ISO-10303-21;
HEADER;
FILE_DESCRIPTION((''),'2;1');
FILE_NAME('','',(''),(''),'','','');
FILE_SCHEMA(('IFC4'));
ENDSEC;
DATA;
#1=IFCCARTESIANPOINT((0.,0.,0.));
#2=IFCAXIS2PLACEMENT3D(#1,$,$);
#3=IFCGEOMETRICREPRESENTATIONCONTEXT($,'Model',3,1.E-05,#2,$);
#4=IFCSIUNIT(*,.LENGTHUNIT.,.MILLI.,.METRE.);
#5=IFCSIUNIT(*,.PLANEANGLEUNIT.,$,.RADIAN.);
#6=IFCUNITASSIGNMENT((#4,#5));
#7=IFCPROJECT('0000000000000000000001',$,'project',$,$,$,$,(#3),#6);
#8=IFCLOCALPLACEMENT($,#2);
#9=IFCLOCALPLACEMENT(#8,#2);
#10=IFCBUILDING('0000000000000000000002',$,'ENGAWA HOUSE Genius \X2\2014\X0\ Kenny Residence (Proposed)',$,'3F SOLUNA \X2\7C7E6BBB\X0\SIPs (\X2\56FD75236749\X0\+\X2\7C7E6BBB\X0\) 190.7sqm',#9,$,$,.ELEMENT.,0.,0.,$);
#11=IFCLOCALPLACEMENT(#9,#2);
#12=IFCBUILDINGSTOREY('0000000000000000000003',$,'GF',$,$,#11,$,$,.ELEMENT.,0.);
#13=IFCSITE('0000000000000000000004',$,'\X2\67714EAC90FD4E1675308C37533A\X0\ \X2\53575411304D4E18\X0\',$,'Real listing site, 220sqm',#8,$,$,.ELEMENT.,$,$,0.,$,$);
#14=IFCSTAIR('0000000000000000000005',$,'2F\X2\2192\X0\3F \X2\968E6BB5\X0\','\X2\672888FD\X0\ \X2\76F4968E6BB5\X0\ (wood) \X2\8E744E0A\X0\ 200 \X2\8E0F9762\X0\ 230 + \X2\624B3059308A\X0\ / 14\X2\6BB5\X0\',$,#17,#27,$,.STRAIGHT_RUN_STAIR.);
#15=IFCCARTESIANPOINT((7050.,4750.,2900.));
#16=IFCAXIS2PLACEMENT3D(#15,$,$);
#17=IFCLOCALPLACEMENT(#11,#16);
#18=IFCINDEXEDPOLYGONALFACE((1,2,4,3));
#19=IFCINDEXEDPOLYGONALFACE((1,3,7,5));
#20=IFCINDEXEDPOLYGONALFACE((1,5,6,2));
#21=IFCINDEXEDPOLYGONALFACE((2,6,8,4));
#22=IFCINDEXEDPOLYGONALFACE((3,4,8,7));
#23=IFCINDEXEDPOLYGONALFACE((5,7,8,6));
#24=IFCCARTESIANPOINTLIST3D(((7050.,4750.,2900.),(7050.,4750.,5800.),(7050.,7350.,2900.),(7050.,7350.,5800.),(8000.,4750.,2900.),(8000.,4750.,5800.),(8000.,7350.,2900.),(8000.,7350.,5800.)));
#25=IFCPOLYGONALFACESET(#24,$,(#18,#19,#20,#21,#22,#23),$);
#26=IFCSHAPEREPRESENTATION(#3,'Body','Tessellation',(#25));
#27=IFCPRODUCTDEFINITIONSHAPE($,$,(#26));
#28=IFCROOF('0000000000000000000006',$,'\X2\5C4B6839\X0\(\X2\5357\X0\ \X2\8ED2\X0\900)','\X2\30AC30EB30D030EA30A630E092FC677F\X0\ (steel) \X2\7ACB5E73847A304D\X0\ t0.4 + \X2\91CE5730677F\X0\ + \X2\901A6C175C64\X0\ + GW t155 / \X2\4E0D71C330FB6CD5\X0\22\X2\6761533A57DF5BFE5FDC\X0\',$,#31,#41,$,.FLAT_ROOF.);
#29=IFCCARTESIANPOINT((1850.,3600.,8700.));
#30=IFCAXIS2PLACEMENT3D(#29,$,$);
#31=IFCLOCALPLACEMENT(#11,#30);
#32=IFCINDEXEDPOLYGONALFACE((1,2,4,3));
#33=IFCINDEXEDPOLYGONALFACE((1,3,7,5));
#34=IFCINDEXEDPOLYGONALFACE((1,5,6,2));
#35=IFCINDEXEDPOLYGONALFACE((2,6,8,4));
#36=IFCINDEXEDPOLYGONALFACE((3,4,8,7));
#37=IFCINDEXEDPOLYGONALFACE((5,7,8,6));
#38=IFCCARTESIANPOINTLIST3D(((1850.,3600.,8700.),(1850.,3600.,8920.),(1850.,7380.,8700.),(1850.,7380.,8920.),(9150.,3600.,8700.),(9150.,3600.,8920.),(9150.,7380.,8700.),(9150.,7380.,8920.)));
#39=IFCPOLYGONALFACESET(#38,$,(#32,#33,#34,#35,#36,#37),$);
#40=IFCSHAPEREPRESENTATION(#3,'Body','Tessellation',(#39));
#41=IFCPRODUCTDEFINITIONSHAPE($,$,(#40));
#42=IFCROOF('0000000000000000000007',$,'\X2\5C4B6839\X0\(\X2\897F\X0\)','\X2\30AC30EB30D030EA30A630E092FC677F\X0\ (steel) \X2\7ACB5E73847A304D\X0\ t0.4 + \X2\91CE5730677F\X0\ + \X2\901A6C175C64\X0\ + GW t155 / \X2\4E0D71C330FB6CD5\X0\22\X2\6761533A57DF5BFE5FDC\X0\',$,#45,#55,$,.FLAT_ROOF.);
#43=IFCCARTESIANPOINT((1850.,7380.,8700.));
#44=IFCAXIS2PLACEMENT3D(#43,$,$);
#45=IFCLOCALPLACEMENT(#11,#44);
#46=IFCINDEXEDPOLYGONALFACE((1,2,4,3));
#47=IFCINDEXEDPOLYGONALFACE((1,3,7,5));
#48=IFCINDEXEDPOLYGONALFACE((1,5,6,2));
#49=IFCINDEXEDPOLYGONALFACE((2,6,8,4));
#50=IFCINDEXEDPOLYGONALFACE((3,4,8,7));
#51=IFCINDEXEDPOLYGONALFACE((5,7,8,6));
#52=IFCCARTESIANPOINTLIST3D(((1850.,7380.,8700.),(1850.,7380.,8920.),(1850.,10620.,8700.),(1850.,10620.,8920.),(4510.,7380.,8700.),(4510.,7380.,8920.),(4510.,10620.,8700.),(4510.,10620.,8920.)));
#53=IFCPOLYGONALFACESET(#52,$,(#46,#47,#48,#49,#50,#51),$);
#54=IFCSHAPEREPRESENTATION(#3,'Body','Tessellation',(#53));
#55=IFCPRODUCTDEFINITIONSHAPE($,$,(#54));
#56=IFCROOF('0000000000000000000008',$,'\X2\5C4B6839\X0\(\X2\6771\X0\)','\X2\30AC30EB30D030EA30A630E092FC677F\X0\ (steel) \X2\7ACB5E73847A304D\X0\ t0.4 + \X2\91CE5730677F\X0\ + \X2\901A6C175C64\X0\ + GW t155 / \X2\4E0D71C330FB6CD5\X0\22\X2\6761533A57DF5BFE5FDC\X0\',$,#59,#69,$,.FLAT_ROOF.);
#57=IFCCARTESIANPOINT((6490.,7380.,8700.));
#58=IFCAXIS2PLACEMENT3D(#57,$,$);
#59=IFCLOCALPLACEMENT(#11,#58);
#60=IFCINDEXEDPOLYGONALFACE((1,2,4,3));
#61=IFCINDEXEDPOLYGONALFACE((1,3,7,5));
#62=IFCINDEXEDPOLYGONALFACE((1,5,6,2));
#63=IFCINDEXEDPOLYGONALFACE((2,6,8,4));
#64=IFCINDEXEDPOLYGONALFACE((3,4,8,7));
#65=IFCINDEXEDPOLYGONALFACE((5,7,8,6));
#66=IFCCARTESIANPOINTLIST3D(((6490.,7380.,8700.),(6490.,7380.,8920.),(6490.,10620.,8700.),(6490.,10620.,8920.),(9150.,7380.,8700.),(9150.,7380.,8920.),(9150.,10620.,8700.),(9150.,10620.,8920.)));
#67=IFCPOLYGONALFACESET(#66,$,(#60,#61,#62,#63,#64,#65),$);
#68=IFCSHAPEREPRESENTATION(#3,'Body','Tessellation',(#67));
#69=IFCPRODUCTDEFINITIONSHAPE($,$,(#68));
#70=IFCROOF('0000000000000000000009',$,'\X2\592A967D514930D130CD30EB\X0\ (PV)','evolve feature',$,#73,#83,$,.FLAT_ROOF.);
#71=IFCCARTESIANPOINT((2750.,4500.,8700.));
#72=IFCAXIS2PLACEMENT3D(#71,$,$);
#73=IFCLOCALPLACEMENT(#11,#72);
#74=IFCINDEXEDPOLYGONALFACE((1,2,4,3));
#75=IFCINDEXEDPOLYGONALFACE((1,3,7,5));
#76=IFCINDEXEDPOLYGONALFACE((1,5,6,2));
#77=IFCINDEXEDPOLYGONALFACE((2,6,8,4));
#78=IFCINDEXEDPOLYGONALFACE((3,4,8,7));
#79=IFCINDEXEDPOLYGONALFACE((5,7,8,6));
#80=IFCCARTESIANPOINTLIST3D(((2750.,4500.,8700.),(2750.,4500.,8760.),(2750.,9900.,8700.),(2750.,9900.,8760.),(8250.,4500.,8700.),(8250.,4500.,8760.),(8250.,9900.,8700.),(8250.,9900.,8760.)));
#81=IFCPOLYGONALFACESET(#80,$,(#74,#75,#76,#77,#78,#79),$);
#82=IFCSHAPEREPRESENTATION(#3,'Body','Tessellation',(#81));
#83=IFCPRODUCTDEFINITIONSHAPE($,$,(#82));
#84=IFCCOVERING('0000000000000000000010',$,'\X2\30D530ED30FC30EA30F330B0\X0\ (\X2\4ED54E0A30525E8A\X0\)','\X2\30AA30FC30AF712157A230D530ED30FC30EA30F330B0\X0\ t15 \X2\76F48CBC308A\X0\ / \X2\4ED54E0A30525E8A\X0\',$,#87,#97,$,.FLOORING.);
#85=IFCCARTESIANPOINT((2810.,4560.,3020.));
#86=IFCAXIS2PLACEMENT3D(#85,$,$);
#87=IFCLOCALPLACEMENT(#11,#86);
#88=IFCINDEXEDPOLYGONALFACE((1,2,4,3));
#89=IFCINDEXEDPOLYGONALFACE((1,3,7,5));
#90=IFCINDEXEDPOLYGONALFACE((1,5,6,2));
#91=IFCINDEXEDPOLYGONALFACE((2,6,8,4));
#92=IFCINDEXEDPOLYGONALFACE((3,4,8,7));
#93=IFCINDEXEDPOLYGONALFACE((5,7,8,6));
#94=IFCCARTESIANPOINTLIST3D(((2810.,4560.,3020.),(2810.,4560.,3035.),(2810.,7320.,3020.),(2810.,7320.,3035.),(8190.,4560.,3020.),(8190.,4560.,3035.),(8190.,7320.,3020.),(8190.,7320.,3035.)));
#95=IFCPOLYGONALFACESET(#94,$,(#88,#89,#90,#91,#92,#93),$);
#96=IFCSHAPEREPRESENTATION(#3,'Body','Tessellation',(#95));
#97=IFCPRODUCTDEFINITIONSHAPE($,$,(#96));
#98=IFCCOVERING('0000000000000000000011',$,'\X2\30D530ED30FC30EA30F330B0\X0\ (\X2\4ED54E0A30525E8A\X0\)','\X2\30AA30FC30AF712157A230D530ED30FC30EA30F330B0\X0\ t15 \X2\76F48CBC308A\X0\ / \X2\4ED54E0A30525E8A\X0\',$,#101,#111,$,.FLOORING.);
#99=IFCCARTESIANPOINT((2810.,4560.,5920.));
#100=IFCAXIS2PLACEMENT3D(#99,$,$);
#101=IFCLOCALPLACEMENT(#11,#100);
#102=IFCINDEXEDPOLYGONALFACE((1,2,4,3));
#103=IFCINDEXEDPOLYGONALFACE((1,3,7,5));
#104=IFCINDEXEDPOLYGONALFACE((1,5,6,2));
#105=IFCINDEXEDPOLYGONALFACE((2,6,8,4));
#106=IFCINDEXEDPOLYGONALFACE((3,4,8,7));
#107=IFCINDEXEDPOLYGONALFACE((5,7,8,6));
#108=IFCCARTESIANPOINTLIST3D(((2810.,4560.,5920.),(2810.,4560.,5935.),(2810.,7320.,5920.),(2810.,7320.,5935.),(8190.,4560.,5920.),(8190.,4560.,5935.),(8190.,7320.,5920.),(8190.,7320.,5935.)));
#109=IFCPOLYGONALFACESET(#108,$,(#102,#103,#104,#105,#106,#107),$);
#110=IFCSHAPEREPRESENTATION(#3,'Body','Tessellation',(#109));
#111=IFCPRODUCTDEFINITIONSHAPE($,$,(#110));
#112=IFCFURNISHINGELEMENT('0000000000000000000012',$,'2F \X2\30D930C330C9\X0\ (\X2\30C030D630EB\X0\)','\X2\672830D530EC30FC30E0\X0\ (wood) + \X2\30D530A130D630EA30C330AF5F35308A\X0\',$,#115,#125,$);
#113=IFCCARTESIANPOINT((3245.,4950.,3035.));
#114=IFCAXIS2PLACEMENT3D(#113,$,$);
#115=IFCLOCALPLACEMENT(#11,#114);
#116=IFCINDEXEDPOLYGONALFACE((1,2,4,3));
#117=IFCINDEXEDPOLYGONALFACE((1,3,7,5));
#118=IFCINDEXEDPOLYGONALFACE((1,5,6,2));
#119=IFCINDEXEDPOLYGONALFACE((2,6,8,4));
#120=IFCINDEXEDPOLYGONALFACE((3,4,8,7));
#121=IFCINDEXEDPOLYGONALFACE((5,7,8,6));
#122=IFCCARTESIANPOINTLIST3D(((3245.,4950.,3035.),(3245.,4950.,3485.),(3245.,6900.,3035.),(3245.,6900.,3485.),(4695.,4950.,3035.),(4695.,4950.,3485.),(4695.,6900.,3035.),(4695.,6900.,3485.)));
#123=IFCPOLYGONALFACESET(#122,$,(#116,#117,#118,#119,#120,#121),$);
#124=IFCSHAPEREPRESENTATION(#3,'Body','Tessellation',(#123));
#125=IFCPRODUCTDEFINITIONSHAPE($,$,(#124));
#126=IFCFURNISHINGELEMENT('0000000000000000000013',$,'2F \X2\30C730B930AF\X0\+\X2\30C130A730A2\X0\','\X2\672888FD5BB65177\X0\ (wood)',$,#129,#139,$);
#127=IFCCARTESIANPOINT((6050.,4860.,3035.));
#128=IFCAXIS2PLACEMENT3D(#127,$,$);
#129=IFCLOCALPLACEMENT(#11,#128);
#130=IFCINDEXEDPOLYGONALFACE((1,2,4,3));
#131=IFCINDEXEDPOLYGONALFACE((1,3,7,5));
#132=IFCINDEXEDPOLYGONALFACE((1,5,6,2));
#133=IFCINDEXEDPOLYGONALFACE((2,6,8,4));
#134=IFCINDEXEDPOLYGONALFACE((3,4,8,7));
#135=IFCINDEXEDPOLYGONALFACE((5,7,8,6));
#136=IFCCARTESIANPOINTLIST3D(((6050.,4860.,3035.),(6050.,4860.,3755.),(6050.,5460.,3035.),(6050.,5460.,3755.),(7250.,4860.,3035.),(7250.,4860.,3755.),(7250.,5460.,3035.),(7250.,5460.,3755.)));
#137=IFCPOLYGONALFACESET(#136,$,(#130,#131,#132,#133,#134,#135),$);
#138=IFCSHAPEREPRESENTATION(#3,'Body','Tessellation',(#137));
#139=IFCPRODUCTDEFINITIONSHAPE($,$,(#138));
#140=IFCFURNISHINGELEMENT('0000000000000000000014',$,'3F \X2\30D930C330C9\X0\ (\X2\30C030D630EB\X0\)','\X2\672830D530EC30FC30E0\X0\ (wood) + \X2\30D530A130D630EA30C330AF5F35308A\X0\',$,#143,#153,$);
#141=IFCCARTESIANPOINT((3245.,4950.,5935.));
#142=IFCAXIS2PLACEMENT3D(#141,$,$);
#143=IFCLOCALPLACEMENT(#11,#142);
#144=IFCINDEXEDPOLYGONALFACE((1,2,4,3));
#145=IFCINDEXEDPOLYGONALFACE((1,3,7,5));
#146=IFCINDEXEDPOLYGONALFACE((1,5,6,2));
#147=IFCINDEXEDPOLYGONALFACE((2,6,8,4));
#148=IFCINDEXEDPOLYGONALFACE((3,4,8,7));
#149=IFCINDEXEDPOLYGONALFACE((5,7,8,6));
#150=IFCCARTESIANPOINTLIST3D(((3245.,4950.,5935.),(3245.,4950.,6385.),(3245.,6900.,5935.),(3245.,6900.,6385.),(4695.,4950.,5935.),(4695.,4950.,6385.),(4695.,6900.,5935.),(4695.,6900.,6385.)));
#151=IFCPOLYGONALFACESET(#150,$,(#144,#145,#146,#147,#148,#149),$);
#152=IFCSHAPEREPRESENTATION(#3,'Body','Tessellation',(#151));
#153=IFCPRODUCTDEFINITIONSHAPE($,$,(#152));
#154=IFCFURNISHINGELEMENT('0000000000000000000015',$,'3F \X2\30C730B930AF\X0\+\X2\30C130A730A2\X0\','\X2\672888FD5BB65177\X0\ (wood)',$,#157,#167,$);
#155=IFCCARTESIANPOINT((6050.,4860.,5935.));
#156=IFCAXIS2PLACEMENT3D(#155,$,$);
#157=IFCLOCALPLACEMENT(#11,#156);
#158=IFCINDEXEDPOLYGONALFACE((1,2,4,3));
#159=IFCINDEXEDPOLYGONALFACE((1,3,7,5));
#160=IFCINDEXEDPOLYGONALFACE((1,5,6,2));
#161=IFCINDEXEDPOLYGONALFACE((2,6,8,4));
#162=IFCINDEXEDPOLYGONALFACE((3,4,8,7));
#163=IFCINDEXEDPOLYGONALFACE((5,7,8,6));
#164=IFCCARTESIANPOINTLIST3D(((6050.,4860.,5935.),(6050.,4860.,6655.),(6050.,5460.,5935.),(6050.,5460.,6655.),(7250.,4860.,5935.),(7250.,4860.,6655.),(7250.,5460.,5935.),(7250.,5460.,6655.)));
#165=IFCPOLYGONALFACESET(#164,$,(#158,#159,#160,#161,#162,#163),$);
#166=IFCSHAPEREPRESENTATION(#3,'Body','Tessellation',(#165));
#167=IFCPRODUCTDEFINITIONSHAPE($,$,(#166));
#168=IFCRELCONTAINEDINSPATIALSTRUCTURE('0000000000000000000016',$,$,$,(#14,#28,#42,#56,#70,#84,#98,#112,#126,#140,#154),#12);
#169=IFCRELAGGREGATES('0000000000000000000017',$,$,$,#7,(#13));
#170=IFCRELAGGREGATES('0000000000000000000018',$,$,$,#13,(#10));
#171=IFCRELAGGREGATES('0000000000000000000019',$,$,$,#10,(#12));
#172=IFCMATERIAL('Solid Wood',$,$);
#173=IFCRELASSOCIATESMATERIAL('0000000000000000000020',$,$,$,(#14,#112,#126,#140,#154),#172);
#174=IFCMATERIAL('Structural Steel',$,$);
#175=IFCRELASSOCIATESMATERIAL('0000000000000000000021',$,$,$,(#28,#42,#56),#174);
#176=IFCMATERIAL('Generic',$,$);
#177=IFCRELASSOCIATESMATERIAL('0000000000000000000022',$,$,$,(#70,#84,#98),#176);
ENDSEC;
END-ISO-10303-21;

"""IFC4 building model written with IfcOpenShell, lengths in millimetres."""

from ifc_helpers import new_model, si_unit, frame, frame_2d, origin, place, context, project, spatial, rectangle, extrude, material, element, save


model = new_model("IFC4")

# Units and contexts
model_context = context("Model", 3, precision=1e-05, world=origin())
ifc_project = project(units=[si_unit("LENGTHUNIT", "METRE", prefix="MILLI"), si_unit("PLANEANGLEUNIT", "RADIAN")], contexts=[model_context])

# Site, building, storey
site_placement = place(None, origin())
site = spatial("IfcSite", under=ifc_project, at=site_placement, Name="東京都世田谷区 南向き丘", ObjectType="Real listing site, 220sqm", CompositionType="ELEMENT", RefElevation=0.0)
building_placement = place(site_placement, origin())
building = spatial("IfcBuilding", under=site, at=building_placement, Name="ENGAWA HOUSE Genius — Kenny Residence (Proposed)", ObjectType="3F SOLUNA 籾殻SIPs (国産杉+籾殻) 190.7sqm", CompositionType="ELEMENT", ElevationOfRefHeight=0.0, ElevationOfTerrain=0.0)
storey_placement = place(building_placement, origin())
storey = spatial("IfcBuildingStorey", under=building, at=storey_placement, Name="GF", CompositionType="ELEMENT", Elevation=0.0)

# Shared definitions
ifc_material_1 = material(Name="Solid Wood")

# Stair
stair_placement = place(storey_placement, frame((7050.0, 4750.0, 2900.0)))
element("IfcStair", 1, at=stair_placement, inside=storey, material=ifc_material_1, Name="2F→3F 階段", Description="木製 直階段 (wood) 蹴上 200 踏面 230 + 手すり / 14段", PredefinedType="STRAIGHT_RUN_STAIR", context=model_context, shape_type="SweptSolid", body=[
    extrude(rectangle(XDim=950.0, YDim=2600.0, at=frame_2d((475.0, 1300.0))), frame((7050.0, 4750.0, 2900.0)), (0.0, 0.0, 1.0), 2900.0),
])

# Roofs
ifc_material_2 = material(Name="Structural Steel")
roof_1_placement = place(storey_placement, frame((1850.0, 3600.0, 8700.0)))
element("IfcRoof", 2, at=roof_1_placement, inside=storey, material=ifc_material_2, Name="屋根(南 軒900)", Description="ガルバリウム鋼板 (steel) 立平葺き t0.4 + 野地板 + 通気層 + GW t155 / 不燃・法22条区域対応", PredefinedType="FLAT_ROOF", context=model_context, shape_type="SweptSolid", body=[
    extrude(rectangle(XDim=7300.0, YDim=3780.0, at=frame_2d((3650.0, 1890.0))), frame((1850.0, 3600.0, 8700.0)), (0.0, 0.0, 1.0), 220.0),
])
roof_2_placement = place(storey_placement, frame((1850.0, 7380.0, 8700.0)))
element("IfcRoof", 3, at=roof_2_placement, inside=storey, material=ifc_material_2, Name="屋根(西)", Description="ガルバリウム鋼板 (steel) 立平葺き t0.4 + 野地板 + 通気層 + GW t155 / 不燃・法22条区域対応", PredefinedType="FLAT_ROOF", context=model_context, shape_type="SweptSolid", body=[
    extrude(rectangle(XDim=2660.0, YDim=3240.0, at=frame_2d((1330.0, 1620.0))), frame((1850.0, 7380.0, 8700.0)), (0.0, 0.0, 1.0), 220.0),
])
roof_3_placement = place(storey_placement, frame((6490.0, 7380.0, 8700.0)))
element("IfcRoof", 4, at=roof_3_placement, inside=storey, material=ifc_material_2, Name="屋根(東)", Description="ガルバリウム鋼板 (steel) 立平葺き t0.4 + 野地板 + 通気層 + GW t155 / 不燃・法22条区域対応", PredefinedType="FLAT_ROOF", context=model_context, shape_type="SweptSolid", body=[
    extrude(rectangle(XDim=2660.0, YDim=3240.0, at=frame_2d((1330.0, 1620.0))), frame((6490.0, 7380.0, 8700.0)), (0.0, 0.0, 1.0), 220.0),
])
ifc_material_3 = material(Name="Generic")
roof_4_placement = place(storey_placement, frame((2750.0, 4500.0, 8700.0)))
element("IfcRoof", 5, at=roof_4_placement, inside=storey, material=ifc_material_3, Name="太陽光パネル (PV)", Description="evolve feature", PredefinedType="FLAT_ROOF", context=model_context, shape_type="SweptSolid", body=[
    extrude(rectangle(XDim=5500.0, YDim=5400.0, at=frame_2d((2750.0, 2700.0))), frame((2750.0, 4500.0, 8700.0)), (0.0, 0.0, 1.0), 60.0),
])

# Coverings
covering_1_placement = place(storey_placement, frame((2810.0, 4560.0, 3020.0)))
element("IfcCovering", 6, at=covering_1_placement, inside=storey, material=ifc_material_3, Name="フローリング (仕上げ床)", Description="オーク無垢フローリング t15 直貼り / 仕上げ床", PredefinedType="FLOORING", context=model_context, shape_type="SweptSolid", body=[
    extrude(rectangle(XDim=5380.0, YDim=2760.0, at=frame_2d((2690.0, 1380.0))), frame((2810.0, 4560.0, 3020.0)), (0.0, 0.0, 1.0), 15.0),
])
covering_2_placement = place(storey_placement, frame((2810.0, 4560.0, 5920.0)))
element("IfcCovering", 7, at=covering_2_placement, inside=storey, material=ifc_material_3, Name="フローリング (仕上げ床)", Description="オーク無垢フローリング t15 直貼り / 仕上げ床", PredefinedType="FLOORING", context=model_context, shape_type="SweptSolid", body=[
    extrude(rectangle(XDim=5380.0, YDim=2760.0, at=frame_2d((2690.0, 1380.0))), frame((2810.0, 4560.0, 5920.0)), (0.0, 0.0, 1.0), 15.0),
])

# Furnishing elements
furnishing_1_placement = place(storey_placement, frame((3245.0, 4950.0, 3035.0)))
element("IfcFurnishingElement", 8, at=furnishing_1_placement, inside=storey, material=ifc_material_1, Name="2F ベッド (ダブル)", Description="木フレーム (wood) + ファブリック張り", context=model_context, shape_type="SweptSolid", body=[
    extrude(rectangle(XDim=1450.0, YDim=1950.0, at=frame_2d((725.0, 975.0))), frame((3245.0, 4950.0, 3035.0)), (0.0, 0.0, 1.0), 450.0),
])
furnishing_2_placement = place(storey_placement, frame((6050.0, 4860.0, 3035.0)))
element("IfcFurnishingElement", 9, at=furnishing_2_placement, inside=storey, material=ifc_material_1, Name="2F デスク+チェア", Description="木製家具 (wood)", context=model_context, shape_type="SweptSolid", body=[
    extrude(rectangle(XDim=1200.0, YDim=600.0, at=frame_2d((600.0, 300.0))), frame((6050.0, 4860.0, 3035.0)), (0.0, 0.0, 1.0), 720.0),
])
furnishing_3_placement = place(storey_placement, frame((3245.0, 4950.0, 5935.0)))
element("IfcFurnishingElement", 10, at=furnishing_3_placement, inside=storey, material=ifc_material_1, Name="3F ベッド (ダブル)", Description="木フレーム (wood) + ファブリック張り", context=model_context, shape_type="SweptSolid", body=[
    extrude(rectangle(XDim=1450.0, YDim=1950.0, at=frame_2d((725.0, 975.0))), frame((3245.0, 4950.0, 5935.0)), (0.0, 0.0, 1.0), 450.0),
])
furnishing_4_placement = place(storey_placement, frame((6050.0, 4860.0, 5935.0)))
element("IfcFurnishingElement", 11, at=furnishing_4_placement, inside=storey, material=ifc_material_1, Name="3F デスク+チェア", Description="木製家具 (wood)", context=model_context, shape_type="SweptSolid", body=[
    extrude(rectangle(XDim=1200.0, YDim=600.0, at=frame_2d((600.0, 300.0))), frame((6050.0, 4860.0, 5935.0)), (0.0, 0.0, 1.0), 720.0),
])

save(model, "model.ifc")
